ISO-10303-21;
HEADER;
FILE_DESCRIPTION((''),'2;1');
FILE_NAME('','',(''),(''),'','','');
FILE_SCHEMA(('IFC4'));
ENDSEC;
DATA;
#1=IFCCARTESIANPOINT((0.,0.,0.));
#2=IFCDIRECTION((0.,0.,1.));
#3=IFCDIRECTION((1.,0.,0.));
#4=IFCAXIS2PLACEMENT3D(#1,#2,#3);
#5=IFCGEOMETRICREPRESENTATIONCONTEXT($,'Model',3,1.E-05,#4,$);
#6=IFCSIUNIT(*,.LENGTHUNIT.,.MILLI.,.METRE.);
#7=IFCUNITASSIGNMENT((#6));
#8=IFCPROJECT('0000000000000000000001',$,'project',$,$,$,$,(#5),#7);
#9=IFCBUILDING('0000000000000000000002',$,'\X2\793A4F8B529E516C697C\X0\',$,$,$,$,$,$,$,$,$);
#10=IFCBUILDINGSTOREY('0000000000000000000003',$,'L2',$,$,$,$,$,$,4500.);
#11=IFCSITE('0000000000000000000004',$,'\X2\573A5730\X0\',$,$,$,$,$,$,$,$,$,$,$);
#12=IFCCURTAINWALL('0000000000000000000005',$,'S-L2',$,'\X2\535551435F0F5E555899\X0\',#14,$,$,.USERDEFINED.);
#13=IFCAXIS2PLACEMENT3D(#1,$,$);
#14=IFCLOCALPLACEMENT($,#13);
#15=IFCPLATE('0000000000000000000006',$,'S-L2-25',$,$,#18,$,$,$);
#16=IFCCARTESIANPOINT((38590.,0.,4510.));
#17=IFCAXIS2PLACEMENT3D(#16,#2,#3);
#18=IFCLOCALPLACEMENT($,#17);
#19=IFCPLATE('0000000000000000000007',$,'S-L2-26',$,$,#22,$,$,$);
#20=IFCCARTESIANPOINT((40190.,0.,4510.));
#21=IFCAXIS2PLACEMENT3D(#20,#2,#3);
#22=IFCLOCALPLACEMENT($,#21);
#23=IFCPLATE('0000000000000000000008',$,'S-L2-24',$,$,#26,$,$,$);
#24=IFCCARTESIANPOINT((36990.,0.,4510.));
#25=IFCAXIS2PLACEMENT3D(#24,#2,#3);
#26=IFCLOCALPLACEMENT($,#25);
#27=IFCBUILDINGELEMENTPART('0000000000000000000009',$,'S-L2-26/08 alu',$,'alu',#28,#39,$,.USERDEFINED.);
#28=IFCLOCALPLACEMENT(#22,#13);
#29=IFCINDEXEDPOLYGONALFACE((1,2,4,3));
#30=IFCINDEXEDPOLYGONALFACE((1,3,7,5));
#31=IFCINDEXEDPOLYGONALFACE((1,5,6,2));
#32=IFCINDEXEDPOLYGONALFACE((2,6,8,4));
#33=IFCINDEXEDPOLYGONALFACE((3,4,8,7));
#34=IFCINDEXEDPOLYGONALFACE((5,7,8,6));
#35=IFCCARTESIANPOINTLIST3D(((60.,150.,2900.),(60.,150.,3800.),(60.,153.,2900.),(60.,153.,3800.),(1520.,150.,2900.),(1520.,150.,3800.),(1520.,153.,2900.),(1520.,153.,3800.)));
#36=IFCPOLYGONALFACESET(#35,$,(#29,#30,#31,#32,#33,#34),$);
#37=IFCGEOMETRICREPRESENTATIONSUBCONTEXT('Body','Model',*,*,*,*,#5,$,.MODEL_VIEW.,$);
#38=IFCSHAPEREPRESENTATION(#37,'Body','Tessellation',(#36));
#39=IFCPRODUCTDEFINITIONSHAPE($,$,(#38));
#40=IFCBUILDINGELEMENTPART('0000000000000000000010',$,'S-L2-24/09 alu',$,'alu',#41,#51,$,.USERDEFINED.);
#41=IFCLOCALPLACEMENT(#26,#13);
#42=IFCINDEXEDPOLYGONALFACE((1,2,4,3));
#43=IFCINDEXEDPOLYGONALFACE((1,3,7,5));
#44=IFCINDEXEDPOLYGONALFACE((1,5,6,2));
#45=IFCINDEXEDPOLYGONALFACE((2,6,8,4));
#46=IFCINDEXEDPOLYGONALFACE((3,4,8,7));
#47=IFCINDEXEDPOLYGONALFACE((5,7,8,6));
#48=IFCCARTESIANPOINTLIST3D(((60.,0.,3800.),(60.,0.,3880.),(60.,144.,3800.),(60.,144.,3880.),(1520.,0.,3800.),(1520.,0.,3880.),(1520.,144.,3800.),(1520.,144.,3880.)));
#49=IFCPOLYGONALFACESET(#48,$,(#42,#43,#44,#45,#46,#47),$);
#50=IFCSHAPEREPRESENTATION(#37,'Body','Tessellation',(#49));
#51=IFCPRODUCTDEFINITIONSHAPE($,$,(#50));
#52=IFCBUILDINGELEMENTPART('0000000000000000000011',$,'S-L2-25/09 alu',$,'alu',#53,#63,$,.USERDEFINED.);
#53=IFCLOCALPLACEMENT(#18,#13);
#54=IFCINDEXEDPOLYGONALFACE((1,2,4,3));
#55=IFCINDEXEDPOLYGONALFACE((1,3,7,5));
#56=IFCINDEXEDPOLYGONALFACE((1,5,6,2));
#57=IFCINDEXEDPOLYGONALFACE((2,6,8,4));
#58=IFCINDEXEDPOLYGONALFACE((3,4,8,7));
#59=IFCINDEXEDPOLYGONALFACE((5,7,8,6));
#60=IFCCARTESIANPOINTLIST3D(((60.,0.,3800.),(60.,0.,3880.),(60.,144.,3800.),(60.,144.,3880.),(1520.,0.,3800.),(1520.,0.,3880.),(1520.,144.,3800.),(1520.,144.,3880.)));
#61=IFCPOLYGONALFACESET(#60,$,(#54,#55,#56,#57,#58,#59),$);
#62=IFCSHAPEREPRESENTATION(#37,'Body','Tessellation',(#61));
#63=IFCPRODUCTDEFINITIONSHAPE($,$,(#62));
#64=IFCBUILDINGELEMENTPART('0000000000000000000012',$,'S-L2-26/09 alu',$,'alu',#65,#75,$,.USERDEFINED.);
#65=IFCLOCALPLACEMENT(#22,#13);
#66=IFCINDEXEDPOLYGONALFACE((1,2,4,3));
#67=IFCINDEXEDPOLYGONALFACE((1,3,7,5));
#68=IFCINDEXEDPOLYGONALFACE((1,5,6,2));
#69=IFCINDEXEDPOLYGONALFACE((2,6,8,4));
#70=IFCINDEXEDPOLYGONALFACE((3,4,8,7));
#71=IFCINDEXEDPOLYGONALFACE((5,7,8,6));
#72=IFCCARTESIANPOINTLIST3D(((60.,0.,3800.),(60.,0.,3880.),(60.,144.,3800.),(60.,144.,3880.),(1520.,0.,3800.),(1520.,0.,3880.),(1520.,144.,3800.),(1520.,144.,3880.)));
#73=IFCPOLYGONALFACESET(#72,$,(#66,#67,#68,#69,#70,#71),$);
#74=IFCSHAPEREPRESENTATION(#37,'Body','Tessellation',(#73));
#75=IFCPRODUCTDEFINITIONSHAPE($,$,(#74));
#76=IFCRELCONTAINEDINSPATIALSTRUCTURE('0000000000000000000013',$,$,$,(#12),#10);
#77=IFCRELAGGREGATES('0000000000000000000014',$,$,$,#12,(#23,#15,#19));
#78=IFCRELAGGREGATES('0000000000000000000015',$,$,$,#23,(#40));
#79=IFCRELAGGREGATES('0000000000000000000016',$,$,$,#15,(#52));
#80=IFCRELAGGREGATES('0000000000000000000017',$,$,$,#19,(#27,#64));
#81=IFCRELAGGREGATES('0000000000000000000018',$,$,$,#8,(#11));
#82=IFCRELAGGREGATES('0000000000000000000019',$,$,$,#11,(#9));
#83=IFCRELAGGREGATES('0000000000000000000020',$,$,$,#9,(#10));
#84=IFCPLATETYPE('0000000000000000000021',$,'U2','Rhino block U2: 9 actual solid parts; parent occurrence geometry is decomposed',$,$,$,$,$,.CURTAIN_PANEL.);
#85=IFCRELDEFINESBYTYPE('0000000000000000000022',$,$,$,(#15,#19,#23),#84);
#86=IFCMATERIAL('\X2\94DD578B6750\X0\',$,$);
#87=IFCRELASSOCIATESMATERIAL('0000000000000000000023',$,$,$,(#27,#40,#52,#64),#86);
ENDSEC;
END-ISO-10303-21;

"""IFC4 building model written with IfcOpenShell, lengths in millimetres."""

from ifc_helpers import new_model, si_unit, frame, frame_2d, origin, origin_with_axes, place, context, subcontext, project, spatial, rectangle, extrude, source, transform, mapped, material, type_object, element, aggregate, save


model = new_model("IFC4")

# Units and contexts
model_context = context("Model", 3, precision=1e-05, world=origin_with_axes())
body_context = subcontext(model_context, "Body", "Model", "MODEL_VIEW")
ifc_project = project(units=[si_unit("LENGTHUNIT", "METRE", prefix="MILLI")], contexts=[model_context])

# Site, building, storey
site = spatial("IfcSite", under=ifc_project, Name="场地")
building = spatial("IfcBuilding", under=site, Name="示例办公楼")
storey = spatial("IfcBuildingStorey", under=building, Name="L2", Elevation=4500.0)

# Curtain wall, plates, building element parts
curtain_wall = element("IfcCurtainWall", 1, inside=storey, Name="S-L2", ObjectType="单元式幕墙", PredefinedType="USERDEFINED")
plate_type = type_object("IfcPlateType", Name="U2", Description="Rhino block U2: 9 actual solid parts; parent occurrence geometry is decomposed", PredefinedType="CURTAIN_PANEL")
plate_1_placement = place(None, frame((38590.0, 0.0, 4510.0), z_axis=(0.0, 0.0, 1.0), x_axis=(1.0, 0.0, 0.0)))
plate_1 = element("IfcPlate", 2, at=plate_1_placement, type_object=plate_type, Name="S-L2-25")
ifc_material_1 = material(Name="铝型材")
plate_2_placement = place(None, frame((40190.0, 0.0, 4510.0), z_axis=(0.0, 0.0, 1.0), x_axis=(1.0, 0.0, 0.0)))
plate_2 = element("IfcPlate", 3, at=plate_2_placement, type_object=plate_type, Name="S-L2-26")
plate_3_placement = place(None, frame((36990.0, 0.0, 4510.0), z_axis=(0.0, 0.0, 1.0), x_axis=(1.0, 0.0, 0.0)))
plate_3 = element("IfcPlate", 4, at=plate_3_placement, type_object=plate_type, Name="S-L2-24")
aggregate(curtain_wall, [plate_3, plate_1, plate_2])
shared_shape_1 = source(origin(), body_context, "Body", "SweptSolid", [
    extrude(rectangle(XDim=1460.0, YDim=3.0, at=frame_2d((790.0, 151.5))), frame((0.0, 0.0, 2900.0)), (0.0, 0.0, 1.0), 900.0),
])
building_element_part_1_placement = place(plate_2_placement, origin())
building_element_part_1 = element("IfcBuildingElementPart", 5, at=building_element_part_1_placement, material=ifc_material_1, Name="S-L2-26/08 alu", ObjectType="alu", PredefinedType="USERDEFINED", context=body_context, shape_type="MappedRepresentation", body=[
    mapped(shared_shape_1, transform((0.0, 0.0, 0.0))),
])
shared_shape_2 = source(origin(), body_context, "Body", "SweptSolid", [
    extrude(rectangle(XDim=1460.0, YDim=144.0, at=frame_2d((790.0, 72.0))), frame((0.0, 0.0, 3800.0)), (0.0, 0.0, 1.0), 80.0),
])
building_element_part_2_placement = place(plate_3_placement, origin())
building_element_part_2 = element("IfcBuildingElementPart", 6, at=building_element_part_2_placement, material=ifc_material_1, Name="S-L2-24/09 alu", ObjectType="alu", PredefinedType="USERDEFINED", context=body_context, shape_type="MappedRepresentation", body=[
    mapped(shared_shape_2, transform((0.0, 0.0, 0.0))),
])
aggregate(plate_3, [building_element_part_2])
building_element_part_3_placement = place(plate_1_placement, origin())
building_element_part_3 = element("IfcBuildingElementPart", 7, at=building_element_part_3_placement, material=ifc_material_1, Name="S-L2-25/09 alu", ObjectType="alu", PredefinedType="USERDEFINED", context=body_context, shape_type="MappedRepresentation", body=[
    mapped(shared_shape_2, transform((0.0, 0.0, 0.0))),
])
aggregate(plate_1, [building_element_part_3])
building_element_part_4_placement = place(plate_2_placement, origin())
building_element_part_4 = element("IfcBuildingElementPart", 8, at=building_element_part_4_placement, material=ifc_material_1, Name="S-L2-26/09 alu", ObjectType="alu", PredefinedType="USERDEFINED", context=body_context, shape_type="MappedRepresentation", body=[
    mapped(shared_shape_2, transform((0.0, 0.0, 0.0))),
])
aggregate(plate_2, [building_element_part_1, building_element_part_4])

save(model, "model.ifc")
